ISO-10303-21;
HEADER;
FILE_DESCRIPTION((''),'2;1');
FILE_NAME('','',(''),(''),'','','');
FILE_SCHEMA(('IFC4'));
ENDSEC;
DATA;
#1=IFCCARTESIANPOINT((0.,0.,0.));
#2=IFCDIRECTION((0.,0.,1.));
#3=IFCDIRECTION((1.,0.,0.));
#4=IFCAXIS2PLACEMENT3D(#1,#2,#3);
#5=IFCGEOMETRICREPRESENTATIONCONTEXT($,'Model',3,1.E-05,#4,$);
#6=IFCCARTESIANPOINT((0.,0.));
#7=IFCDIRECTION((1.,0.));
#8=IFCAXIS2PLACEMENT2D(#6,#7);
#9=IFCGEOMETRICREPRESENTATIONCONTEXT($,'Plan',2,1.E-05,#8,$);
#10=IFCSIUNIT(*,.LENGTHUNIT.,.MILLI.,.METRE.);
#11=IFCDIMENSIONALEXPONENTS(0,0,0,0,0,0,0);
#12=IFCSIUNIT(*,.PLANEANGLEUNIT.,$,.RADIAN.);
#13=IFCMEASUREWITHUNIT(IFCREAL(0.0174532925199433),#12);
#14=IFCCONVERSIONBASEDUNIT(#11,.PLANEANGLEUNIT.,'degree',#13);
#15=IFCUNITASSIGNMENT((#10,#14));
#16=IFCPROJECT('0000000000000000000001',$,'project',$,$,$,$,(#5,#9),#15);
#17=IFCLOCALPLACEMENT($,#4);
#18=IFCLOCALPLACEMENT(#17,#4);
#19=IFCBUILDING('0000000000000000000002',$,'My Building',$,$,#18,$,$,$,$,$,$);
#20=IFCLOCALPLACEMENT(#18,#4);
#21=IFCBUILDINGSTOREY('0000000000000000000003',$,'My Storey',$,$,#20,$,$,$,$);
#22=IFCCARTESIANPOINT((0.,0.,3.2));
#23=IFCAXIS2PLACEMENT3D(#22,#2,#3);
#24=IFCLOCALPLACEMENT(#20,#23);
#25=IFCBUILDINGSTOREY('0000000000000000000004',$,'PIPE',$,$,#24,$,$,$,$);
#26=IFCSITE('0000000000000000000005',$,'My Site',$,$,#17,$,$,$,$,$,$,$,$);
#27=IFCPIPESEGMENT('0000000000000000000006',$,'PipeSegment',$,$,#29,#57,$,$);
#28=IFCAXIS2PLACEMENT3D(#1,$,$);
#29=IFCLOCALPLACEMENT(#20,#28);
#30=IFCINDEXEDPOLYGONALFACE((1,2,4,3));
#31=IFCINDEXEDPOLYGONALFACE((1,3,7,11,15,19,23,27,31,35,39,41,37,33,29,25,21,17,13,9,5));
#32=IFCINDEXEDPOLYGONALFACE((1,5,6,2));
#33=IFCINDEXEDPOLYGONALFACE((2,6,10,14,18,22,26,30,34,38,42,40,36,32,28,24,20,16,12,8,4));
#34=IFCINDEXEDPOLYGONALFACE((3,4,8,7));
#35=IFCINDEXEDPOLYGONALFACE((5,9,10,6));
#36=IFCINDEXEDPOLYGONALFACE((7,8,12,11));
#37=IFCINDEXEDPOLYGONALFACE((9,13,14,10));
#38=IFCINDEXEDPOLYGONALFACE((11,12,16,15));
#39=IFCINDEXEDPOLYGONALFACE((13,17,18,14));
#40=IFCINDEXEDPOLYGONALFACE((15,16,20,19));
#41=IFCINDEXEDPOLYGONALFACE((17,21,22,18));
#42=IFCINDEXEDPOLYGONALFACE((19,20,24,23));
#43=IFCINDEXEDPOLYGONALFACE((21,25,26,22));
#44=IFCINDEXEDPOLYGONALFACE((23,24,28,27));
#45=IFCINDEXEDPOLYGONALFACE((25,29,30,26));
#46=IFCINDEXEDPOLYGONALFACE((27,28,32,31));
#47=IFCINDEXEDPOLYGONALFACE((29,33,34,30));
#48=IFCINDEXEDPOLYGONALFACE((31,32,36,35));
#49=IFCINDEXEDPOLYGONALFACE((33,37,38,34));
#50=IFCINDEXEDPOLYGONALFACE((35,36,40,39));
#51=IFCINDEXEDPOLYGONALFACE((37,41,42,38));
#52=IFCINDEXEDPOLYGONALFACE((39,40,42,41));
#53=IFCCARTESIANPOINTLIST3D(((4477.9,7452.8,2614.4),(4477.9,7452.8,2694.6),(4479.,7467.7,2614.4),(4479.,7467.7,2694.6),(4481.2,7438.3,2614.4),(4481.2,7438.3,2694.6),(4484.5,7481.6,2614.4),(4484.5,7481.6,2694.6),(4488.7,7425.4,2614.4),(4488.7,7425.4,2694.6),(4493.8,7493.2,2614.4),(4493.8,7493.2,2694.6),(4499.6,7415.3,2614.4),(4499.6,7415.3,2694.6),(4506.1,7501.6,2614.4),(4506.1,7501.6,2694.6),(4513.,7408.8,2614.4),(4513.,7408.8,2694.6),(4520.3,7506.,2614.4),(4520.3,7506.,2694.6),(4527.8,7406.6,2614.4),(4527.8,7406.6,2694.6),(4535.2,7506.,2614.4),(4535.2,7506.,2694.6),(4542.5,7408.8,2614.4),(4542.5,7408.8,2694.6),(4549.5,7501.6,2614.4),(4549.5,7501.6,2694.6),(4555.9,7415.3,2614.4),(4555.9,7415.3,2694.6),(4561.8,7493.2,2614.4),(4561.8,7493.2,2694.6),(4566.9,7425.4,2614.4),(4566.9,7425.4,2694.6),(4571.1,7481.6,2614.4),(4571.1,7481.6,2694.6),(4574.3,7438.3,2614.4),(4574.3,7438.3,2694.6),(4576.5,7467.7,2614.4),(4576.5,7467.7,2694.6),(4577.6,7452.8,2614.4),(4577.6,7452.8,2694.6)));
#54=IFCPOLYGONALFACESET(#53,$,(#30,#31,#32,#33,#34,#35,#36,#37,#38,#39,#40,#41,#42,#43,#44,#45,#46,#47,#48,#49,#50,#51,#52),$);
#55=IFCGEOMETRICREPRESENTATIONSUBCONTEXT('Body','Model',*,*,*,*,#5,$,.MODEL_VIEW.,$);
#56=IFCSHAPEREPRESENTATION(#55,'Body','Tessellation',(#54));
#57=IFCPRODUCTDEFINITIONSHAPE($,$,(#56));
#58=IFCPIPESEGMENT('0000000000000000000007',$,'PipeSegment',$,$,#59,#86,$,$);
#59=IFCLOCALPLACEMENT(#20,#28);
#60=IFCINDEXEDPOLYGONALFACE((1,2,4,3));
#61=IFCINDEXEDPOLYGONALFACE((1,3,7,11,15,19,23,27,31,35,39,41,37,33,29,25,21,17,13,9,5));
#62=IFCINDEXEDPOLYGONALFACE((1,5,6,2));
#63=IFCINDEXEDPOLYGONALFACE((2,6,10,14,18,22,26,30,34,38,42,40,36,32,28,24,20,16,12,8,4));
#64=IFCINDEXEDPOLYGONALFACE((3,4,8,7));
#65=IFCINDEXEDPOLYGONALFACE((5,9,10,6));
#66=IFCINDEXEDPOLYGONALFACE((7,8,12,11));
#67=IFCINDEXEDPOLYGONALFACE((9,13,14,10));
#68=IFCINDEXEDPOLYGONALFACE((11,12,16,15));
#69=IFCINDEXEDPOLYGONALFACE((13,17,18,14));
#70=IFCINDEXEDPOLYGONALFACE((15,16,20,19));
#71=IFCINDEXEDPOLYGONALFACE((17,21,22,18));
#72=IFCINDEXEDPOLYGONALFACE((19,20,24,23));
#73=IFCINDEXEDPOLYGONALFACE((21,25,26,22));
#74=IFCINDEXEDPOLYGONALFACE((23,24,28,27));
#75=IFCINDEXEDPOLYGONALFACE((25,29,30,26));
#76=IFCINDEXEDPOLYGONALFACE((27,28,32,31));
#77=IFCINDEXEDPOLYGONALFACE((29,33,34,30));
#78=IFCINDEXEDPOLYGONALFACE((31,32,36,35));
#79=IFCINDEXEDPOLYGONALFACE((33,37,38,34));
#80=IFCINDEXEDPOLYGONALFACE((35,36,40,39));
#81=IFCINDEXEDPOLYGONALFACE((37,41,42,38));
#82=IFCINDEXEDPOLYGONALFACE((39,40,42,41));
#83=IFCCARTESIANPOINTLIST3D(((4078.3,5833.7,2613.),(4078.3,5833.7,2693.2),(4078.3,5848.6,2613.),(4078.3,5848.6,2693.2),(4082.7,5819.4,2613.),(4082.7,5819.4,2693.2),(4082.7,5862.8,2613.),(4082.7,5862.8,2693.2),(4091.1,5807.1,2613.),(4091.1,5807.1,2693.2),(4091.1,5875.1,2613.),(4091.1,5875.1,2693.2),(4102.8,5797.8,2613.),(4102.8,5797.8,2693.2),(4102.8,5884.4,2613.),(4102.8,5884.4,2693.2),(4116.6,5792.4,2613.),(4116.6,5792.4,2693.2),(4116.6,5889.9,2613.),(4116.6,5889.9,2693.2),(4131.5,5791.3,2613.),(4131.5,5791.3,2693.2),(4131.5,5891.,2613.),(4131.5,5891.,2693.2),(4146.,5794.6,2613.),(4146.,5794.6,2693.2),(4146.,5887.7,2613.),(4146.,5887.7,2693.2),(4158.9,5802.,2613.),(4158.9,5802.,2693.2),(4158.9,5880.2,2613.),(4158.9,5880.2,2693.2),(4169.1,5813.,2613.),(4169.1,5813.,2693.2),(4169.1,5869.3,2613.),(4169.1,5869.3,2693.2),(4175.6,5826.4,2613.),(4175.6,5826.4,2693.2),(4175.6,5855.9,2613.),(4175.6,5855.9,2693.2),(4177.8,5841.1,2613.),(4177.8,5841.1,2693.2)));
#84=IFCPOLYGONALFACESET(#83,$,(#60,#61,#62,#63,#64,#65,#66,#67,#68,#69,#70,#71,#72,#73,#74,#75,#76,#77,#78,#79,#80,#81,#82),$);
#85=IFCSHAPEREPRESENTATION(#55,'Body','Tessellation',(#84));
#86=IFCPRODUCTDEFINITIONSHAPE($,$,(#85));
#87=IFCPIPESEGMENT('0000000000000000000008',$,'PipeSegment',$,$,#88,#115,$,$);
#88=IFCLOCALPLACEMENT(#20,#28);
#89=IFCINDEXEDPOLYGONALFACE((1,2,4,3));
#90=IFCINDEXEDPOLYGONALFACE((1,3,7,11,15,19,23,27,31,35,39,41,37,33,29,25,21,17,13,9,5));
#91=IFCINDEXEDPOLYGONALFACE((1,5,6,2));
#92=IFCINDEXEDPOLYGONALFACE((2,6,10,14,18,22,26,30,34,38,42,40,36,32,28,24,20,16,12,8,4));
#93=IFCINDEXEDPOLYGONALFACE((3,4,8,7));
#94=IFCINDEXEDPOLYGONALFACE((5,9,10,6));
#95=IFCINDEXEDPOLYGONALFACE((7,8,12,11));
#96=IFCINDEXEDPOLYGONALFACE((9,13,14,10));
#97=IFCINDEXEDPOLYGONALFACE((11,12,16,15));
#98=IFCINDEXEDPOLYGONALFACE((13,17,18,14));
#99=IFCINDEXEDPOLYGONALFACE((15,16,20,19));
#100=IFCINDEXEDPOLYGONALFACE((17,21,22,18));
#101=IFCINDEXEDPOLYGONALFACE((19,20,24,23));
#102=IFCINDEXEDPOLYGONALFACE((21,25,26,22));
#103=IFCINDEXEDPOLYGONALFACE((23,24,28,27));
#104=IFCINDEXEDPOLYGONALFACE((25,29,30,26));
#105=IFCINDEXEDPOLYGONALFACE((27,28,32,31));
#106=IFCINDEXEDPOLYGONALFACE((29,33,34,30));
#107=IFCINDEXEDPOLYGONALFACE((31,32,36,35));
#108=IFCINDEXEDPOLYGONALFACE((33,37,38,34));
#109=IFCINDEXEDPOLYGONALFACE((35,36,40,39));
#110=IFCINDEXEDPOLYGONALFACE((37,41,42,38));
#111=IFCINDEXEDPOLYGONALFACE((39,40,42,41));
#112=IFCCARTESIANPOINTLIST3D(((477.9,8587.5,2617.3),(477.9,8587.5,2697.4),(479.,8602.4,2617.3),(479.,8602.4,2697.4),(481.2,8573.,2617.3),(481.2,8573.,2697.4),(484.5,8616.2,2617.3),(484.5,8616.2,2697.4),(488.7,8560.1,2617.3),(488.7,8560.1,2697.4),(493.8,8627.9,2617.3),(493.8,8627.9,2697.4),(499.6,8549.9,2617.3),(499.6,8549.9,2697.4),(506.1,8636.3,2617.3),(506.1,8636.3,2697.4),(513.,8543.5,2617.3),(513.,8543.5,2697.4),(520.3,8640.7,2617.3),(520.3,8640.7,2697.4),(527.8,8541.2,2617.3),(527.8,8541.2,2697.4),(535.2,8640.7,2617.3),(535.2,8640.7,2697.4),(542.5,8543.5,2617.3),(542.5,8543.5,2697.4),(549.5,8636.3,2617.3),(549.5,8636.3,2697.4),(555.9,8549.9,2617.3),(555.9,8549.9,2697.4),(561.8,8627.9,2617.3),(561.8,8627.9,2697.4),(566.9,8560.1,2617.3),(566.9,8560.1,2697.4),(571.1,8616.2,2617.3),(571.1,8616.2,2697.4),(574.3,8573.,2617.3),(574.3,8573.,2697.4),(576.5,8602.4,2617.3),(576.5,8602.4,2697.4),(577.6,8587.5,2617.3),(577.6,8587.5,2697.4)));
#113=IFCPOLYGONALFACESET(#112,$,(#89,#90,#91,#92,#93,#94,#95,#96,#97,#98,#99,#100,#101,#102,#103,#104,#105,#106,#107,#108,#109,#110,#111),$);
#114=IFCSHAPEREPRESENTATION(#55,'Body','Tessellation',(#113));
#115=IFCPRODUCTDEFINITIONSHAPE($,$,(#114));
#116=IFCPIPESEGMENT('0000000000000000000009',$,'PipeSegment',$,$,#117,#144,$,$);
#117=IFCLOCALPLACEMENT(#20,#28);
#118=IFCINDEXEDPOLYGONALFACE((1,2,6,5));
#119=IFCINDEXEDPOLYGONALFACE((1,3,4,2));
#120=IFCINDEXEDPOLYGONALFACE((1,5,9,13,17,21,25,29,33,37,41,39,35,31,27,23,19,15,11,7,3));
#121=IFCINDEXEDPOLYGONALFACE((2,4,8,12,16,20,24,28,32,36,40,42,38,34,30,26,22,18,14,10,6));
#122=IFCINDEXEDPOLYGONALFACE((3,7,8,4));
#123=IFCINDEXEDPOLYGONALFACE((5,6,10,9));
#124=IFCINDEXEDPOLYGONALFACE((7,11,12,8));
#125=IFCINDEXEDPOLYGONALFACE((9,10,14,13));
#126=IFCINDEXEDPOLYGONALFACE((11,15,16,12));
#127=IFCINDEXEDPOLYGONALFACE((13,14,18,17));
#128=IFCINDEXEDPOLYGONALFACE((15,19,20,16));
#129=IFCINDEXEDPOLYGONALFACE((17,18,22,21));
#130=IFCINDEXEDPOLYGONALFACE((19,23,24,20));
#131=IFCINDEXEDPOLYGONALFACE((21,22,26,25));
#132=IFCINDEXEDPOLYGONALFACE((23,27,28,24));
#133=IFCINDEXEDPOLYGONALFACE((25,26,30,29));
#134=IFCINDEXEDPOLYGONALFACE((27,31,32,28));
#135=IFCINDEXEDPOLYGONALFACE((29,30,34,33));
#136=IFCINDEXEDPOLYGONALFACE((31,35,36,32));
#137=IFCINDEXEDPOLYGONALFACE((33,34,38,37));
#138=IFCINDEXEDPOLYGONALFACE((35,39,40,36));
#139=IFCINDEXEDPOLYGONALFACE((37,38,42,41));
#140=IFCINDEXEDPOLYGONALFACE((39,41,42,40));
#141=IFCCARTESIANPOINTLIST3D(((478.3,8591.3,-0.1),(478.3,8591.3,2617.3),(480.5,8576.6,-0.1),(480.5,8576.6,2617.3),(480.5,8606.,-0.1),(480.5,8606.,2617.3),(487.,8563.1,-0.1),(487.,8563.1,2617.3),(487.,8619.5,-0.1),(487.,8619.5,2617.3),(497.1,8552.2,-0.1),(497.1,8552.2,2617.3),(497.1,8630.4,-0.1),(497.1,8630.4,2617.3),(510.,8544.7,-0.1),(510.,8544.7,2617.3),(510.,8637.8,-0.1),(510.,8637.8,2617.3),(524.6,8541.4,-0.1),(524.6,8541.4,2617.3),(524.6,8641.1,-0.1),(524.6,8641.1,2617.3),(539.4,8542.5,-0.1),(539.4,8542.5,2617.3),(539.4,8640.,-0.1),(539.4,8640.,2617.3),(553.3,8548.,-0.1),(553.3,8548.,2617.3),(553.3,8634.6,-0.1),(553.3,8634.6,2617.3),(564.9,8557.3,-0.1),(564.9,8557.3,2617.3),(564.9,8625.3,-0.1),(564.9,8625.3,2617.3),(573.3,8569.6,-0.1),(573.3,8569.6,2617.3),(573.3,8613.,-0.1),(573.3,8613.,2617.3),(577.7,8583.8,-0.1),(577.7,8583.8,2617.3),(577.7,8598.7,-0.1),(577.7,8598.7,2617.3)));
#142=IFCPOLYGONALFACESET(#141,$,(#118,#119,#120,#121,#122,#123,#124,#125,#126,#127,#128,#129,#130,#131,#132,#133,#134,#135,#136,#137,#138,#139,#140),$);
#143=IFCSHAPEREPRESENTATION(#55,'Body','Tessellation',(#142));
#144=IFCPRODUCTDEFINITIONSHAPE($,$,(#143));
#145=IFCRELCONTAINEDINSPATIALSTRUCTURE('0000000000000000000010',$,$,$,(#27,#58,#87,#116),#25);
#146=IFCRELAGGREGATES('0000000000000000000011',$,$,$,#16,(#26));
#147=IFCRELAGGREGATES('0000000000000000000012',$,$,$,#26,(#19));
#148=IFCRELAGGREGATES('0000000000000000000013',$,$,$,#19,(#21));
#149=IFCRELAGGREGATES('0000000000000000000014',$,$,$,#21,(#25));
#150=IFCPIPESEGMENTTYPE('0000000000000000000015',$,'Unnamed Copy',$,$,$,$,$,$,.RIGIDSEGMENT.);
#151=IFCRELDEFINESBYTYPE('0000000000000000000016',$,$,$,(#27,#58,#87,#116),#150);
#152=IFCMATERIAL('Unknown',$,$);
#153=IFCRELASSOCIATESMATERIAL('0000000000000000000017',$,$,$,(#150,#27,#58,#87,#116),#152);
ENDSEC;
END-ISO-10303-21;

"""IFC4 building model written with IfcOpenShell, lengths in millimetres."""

from ifc_helpers import new_model, entity, si_unit, converted_unit, frame, origin_with_axes, origin_2d_with_axis, place, context, subcontext, project, spatial, circle, extrude, material, material_profile, profile_set, profile_usage, type_object, element, save


model = new_model("IFC4")

# Units and contexts
model_context = context("Model", 3, precision=1e-05, world=origin_with_axes())
plan_context = context("Plan", 2, precision=1e-05, world=origin_2d_with_axis())
body_context = subcontext(model_context, "Body", "Model", "MODEL_VIEW")
ifc_project = project(units=[si_unit("LENGTHUNIT", "METRE", prefix="MILLI"), converted_unit("PLANEANGLEUNIT", "degree", entity("IfcReal", 0.0174532925199433), si_unit("PLANEANGLEUNIT", "RADIAN"), dimensions=[0, 0, 0, 0, 0, 0, 0])], contexts=[model_context, plan_context])

# Site, building, storeys
site_placement = place(None, origin_with_axes())
site = spatial("IfcSite", under=ifc_project, at=site_placement, Name="My Site")
building_placement = place(site_placement, origin_with_axes())
building = spatial("IfcBuilding", under=site, at=building_placement, Name="My Building")
storey_1_placement = place(building_placement, origin_with_axes())
storey_1 = spatial("IfcBuildingStorey", under=building, at=storey_1_placement, Name="My Storey")
storey_2_placement = place(storey_1_placement, frame((0.0, 0.0, 3.2), z_axis=(0.0, 0.0, 1.0), x_axis=(1.0, 0.0, 0.0)))
storey_2 = spatial("IfcBuildingStorey", under=storey_1, at=storey_2_placement, Name="PIPE")

# Shared definitions
ifc_material = material(Name="Unknown")

# Pipe segments
ifc_material_profile_1 = material_profile(ifc_material, circle(Radius=50.0))
ifc_profile_set_1 = profile_set([ifc_material_profile_1])
pipe_segment_type = type_object("IfcPipeSegmentType", Name="Unnamed Copy", PredefinedType="RIGIDSEGMENT", material=ifc_profile_set_1)
ifc_profile_usage_1 = profile_usage(ifc_profile_set_1, cardinal=10)
pipe_segment_1_placement = place(storey_2_placement, frame((4527.8, 7456.6, 2691.4), z_axis=(0.0, -0.000001, -1.0), x_axis=(0.0, -1.0, 0.000001)))
element("IfcPipeSegment", 1, at=pipe_segment_1_placement, inside=storey_2, type_object=pipe_segment_type, material=ifc_profile_usage_1, Name="PipeSegment", context=body_context, shape_type="SweptSolid", body=[
    extrude(circle(Radius=50.0), origin_with_axes(), (0.0, 0.0, 1.0), 80.1),
])
ifc_profile_usage_2 = profile_usage(ifc_profile_set_1, cardinal=10)
pipe_segment_2_placement = place(storey_2_placement, frame((4127.8, 5841.1, 2690.0), z_axis=(0.0, 0.0, -1.0), x_axis=(1.0, 0.0, 0.0)))
element("IfcPipeSegment", 2, at=pipe_segment_2_placement, inside=storey_2, type_object=pipe_segment_type, material=ifc_profile_usage_2, Name="PipeSegment", context=body_context, shape_type="SweptSolid", body=[
    extrude(circle(Radius=50.0), origin_with_axes(), (0.0, 0.0, 1.0), 80.1),
])
ifc_profile_usage_3 = profile_usage(ifc_profile_set_1, cardinal=10)
pipe_segment_3_placement = place(storey_2_placement, frame((527.8, 8591.2, 2694.2), z_axis=(0.0, -0.000001, -1.0), x_axis=(0.0, -1.0, 0.000001)))
element("IfcPipeSegment", 3, at=pipe_segment_3_placement, inside=storey_2, type_object=pipe_segment_type, material=ifc_profile_usage_3, Name="PipeSegment", context=body_context, shape_type="SweptSolid", body=[
    extrude(circle(Radius=50.0), origin_with_axes(), (0.0, 0.0, 1.0), 80.1),
])
ifc_profile_usage_4 = profile_usage(ifc_profile_set_1, cardinal=10)
pipe_segment_4_placement = place(storey_2_placement, frame((528.3, 8591.3, 2614.1), z_axis=(0.0, 0.0, -1.0), x_axis=(-1.0, 0.0, 0.0)))
element("IfcPipeSegment", 4, at=pipe_segment_4_placement, inside=storey_2, type_object=pipe_segment_type, material=ifc_profile_usage_4, Name="PipeSegment", context=body_context, shape_type="SweptSolid", body=[
    extrude(circle(Radius=50.0), origin_with_axes(), (0.0, 0.0, 1.0), 2617.4),
])

save(model, "model.ifc")
